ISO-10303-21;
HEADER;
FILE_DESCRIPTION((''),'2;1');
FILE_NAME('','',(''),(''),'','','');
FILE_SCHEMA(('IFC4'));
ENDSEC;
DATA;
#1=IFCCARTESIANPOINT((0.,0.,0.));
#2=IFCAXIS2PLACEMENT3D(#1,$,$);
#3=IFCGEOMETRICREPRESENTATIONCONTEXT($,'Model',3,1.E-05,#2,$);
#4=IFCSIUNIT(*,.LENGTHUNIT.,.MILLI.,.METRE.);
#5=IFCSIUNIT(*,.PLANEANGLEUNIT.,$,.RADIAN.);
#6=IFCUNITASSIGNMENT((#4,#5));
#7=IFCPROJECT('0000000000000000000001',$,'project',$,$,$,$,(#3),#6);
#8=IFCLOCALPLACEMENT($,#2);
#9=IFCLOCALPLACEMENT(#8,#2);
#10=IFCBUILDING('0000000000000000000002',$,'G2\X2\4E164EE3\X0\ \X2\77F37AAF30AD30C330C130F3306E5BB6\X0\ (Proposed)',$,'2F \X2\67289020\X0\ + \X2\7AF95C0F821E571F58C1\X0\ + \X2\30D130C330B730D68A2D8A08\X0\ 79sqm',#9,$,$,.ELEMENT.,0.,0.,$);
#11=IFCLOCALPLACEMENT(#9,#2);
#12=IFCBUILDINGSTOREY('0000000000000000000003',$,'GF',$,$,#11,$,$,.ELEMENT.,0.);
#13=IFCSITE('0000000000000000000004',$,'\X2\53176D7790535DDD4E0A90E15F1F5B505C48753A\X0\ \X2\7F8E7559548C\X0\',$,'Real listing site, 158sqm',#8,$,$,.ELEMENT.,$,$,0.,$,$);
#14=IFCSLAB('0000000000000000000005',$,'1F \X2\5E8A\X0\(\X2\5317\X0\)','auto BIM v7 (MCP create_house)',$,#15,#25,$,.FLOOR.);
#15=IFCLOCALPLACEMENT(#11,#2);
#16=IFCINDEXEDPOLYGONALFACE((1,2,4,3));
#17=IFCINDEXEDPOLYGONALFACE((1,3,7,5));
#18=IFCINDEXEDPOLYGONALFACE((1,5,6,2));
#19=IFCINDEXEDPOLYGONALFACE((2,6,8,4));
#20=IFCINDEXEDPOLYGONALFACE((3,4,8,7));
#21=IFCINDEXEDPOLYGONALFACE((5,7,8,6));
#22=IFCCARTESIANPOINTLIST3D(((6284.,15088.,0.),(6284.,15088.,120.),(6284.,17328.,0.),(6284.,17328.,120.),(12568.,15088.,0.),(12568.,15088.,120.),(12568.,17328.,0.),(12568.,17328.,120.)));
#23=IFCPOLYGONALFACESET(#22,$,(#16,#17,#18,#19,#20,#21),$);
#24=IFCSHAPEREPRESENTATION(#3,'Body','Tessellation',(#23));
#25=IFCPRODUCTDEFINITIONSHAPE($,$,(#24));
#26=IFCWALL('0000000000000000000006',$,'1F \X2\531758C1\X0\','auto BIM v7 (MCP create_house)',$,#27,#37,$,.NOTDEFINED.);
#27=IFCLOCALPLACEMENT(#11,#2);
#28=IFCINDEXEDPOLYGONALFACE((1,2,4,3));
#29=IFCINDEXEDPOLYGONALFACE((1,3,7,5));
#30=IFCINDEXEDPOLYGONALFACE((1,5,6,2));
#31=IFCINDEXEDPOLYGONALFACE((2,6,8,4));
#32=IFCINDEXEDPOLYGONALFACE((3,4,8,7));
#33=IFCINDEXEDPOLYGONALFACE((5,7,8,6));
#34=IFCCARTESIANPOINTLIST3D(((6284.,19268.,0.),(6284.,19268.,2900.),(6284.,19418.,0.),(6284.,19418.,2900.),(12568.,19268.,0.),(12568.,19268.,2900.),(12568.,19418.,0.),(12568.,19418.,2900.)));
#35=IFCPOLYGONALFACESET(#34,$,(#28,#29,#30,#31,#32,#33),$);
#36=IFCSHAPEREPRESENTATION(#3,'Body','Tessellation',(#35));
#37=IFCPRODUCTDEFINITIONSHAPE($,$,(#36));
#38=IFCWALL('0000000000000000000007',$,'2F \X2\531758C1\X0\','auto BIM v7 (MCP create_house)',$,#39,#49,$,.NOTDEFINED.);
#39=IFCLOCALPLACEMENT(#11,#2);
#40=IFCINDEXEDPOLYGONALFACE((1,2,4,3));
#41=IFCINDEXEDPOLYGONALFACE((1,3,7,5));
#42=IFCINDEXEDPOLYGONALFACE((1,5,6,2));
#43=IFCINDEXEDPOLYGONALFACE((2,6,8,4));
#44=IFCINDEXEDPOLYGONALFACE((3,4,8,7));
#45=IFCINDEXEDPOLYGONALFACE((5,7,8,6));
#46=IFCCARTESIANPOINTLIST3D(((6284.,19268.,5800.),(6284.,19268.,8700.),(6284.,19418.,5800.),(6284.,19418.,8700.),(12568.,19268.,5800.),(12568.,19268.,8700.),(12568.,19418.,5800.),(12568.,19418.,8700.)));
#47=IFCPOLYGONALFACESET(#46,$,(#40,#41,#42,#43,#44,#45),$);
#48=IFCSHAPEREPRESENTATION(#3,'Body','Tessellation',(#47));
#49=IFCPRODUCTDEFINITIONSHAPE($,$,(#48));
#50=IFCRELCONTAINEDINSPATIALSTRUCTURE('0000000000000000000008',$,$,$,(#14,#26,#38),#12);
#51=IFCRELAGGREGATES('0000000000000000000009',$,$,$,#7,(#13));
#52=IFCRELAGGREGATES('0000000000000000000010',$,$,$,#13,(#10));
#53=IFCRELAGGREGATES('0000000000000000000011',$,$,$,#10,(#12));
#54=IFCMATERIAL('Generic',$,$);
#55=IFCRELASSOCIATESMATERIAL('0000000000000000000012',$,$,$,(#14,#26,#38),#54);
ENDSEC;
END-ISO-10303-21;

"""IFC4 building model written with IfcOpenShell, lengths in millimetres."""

from ifc_helpers import new_model, si_unit, frame, frame_2d, origin, place, context, project, spatial, rectangle, extrude, material, element, save


model = new_model("IFC4")

# Units and contexts
model_context = context("Model", 3, precision=1e-05, world=origin())
ifc_project = project(units=[si_unit("LENGTHUNIT", "METRE", prefix="MILLI"), si_unit("PLANEANGLEUNIT", "RADIAN")], contexts=[model_context])

# Site, building, storey
site_placement = place(None, origin())
site = spatial("IfcSite", under=ifc_project, at=site_placement, Name="北海道川上郡弟子屈町 美留和", ObjectType="Real listing site, 158sqm", CompositionType="ELEMENT", RefElevation=0.0)
building_placement = place(site_placement, origin())
building = spatial("IfcBuilding", under=site, at=building_placement, Name="G2世代 石窯キッチンの家 (Proposed)", ObjectType="2F 木造 + 竹小舞土壁 + パッシブ設計 79sqm", CompositionType="ELEMENT", ElevationOfRefHeight=0.0, ElevationOfTerrain=0.0)
storey_placement = place(building_placement, origin())
storey = spatial("IfcBuildingStorey", under=building, at=storey_placement, Name="GF", CompositionType="ELEMENT", Elevation=0.0)

# Slab
ifc_material = material(Name="Generic")
slab_1_placement = place(storey_placement, frame((3142.0, 7544.0, 0.0)))
element("IfcSlab", 1, at=slab_1_placement, inside=storey, material=ifc_material, Name="1F 床(北)", Description="auto BIM v7 (MCP create_house)", PredefinedType="FLOOR", context=model_context, shape_type="SweptSolid", body=[
    extrude(rectangle(XDim=6284.0, YDim=2240.0, at=frame_2d((3142.0, 1120.0))), frame((3142.0, 7544.0, 0.0)), (0.0, 0.0, 1.0), 120.0),
])

# Wall
wall_1_placement = place(storey_placement, frame((3142.0, 9634.0, 0.0)))
element("IfcWall", 2, at=wall_1_placement, inside=storey, material=ifc_material, Name="1F 北壁", Description="auto BIM v7 (MCP create_house)", PredefinedType="NOTDEFINED", context=model_context, shape_type="SweptSolid", body=[
    extrude(rectangle(XDim=6284.0, YDim=150.0, at=frame_2d((3142.0, 75.0))), frame((3142.0, 9634.0, 0.0)), (0.0, 0.0, 1.0), 2900.0),
])

# Wall
wall_2_placement = place(storey_placement, frame((3142.0, 9634.0, 2900.0)))
element("IfcWall", 3, at=wall_2_placement, inside=storey, material=ifc_material, Name="2F 北壁", Description="auto BIM v7 (MCP create_house)", PredefinedType="NOTDEFINED", context=model_context, shape_type="SweptSolid", body=[
    extrude(rectangle(XDim=6284.0, YDim=150.0, at=frame_2d((3142.0, 75.0))), frame((3142.0, 9634.0, 2900.0)), (0.0, 0.0, 1.0), 2900.0),
])

save(model, "model.ifc")
